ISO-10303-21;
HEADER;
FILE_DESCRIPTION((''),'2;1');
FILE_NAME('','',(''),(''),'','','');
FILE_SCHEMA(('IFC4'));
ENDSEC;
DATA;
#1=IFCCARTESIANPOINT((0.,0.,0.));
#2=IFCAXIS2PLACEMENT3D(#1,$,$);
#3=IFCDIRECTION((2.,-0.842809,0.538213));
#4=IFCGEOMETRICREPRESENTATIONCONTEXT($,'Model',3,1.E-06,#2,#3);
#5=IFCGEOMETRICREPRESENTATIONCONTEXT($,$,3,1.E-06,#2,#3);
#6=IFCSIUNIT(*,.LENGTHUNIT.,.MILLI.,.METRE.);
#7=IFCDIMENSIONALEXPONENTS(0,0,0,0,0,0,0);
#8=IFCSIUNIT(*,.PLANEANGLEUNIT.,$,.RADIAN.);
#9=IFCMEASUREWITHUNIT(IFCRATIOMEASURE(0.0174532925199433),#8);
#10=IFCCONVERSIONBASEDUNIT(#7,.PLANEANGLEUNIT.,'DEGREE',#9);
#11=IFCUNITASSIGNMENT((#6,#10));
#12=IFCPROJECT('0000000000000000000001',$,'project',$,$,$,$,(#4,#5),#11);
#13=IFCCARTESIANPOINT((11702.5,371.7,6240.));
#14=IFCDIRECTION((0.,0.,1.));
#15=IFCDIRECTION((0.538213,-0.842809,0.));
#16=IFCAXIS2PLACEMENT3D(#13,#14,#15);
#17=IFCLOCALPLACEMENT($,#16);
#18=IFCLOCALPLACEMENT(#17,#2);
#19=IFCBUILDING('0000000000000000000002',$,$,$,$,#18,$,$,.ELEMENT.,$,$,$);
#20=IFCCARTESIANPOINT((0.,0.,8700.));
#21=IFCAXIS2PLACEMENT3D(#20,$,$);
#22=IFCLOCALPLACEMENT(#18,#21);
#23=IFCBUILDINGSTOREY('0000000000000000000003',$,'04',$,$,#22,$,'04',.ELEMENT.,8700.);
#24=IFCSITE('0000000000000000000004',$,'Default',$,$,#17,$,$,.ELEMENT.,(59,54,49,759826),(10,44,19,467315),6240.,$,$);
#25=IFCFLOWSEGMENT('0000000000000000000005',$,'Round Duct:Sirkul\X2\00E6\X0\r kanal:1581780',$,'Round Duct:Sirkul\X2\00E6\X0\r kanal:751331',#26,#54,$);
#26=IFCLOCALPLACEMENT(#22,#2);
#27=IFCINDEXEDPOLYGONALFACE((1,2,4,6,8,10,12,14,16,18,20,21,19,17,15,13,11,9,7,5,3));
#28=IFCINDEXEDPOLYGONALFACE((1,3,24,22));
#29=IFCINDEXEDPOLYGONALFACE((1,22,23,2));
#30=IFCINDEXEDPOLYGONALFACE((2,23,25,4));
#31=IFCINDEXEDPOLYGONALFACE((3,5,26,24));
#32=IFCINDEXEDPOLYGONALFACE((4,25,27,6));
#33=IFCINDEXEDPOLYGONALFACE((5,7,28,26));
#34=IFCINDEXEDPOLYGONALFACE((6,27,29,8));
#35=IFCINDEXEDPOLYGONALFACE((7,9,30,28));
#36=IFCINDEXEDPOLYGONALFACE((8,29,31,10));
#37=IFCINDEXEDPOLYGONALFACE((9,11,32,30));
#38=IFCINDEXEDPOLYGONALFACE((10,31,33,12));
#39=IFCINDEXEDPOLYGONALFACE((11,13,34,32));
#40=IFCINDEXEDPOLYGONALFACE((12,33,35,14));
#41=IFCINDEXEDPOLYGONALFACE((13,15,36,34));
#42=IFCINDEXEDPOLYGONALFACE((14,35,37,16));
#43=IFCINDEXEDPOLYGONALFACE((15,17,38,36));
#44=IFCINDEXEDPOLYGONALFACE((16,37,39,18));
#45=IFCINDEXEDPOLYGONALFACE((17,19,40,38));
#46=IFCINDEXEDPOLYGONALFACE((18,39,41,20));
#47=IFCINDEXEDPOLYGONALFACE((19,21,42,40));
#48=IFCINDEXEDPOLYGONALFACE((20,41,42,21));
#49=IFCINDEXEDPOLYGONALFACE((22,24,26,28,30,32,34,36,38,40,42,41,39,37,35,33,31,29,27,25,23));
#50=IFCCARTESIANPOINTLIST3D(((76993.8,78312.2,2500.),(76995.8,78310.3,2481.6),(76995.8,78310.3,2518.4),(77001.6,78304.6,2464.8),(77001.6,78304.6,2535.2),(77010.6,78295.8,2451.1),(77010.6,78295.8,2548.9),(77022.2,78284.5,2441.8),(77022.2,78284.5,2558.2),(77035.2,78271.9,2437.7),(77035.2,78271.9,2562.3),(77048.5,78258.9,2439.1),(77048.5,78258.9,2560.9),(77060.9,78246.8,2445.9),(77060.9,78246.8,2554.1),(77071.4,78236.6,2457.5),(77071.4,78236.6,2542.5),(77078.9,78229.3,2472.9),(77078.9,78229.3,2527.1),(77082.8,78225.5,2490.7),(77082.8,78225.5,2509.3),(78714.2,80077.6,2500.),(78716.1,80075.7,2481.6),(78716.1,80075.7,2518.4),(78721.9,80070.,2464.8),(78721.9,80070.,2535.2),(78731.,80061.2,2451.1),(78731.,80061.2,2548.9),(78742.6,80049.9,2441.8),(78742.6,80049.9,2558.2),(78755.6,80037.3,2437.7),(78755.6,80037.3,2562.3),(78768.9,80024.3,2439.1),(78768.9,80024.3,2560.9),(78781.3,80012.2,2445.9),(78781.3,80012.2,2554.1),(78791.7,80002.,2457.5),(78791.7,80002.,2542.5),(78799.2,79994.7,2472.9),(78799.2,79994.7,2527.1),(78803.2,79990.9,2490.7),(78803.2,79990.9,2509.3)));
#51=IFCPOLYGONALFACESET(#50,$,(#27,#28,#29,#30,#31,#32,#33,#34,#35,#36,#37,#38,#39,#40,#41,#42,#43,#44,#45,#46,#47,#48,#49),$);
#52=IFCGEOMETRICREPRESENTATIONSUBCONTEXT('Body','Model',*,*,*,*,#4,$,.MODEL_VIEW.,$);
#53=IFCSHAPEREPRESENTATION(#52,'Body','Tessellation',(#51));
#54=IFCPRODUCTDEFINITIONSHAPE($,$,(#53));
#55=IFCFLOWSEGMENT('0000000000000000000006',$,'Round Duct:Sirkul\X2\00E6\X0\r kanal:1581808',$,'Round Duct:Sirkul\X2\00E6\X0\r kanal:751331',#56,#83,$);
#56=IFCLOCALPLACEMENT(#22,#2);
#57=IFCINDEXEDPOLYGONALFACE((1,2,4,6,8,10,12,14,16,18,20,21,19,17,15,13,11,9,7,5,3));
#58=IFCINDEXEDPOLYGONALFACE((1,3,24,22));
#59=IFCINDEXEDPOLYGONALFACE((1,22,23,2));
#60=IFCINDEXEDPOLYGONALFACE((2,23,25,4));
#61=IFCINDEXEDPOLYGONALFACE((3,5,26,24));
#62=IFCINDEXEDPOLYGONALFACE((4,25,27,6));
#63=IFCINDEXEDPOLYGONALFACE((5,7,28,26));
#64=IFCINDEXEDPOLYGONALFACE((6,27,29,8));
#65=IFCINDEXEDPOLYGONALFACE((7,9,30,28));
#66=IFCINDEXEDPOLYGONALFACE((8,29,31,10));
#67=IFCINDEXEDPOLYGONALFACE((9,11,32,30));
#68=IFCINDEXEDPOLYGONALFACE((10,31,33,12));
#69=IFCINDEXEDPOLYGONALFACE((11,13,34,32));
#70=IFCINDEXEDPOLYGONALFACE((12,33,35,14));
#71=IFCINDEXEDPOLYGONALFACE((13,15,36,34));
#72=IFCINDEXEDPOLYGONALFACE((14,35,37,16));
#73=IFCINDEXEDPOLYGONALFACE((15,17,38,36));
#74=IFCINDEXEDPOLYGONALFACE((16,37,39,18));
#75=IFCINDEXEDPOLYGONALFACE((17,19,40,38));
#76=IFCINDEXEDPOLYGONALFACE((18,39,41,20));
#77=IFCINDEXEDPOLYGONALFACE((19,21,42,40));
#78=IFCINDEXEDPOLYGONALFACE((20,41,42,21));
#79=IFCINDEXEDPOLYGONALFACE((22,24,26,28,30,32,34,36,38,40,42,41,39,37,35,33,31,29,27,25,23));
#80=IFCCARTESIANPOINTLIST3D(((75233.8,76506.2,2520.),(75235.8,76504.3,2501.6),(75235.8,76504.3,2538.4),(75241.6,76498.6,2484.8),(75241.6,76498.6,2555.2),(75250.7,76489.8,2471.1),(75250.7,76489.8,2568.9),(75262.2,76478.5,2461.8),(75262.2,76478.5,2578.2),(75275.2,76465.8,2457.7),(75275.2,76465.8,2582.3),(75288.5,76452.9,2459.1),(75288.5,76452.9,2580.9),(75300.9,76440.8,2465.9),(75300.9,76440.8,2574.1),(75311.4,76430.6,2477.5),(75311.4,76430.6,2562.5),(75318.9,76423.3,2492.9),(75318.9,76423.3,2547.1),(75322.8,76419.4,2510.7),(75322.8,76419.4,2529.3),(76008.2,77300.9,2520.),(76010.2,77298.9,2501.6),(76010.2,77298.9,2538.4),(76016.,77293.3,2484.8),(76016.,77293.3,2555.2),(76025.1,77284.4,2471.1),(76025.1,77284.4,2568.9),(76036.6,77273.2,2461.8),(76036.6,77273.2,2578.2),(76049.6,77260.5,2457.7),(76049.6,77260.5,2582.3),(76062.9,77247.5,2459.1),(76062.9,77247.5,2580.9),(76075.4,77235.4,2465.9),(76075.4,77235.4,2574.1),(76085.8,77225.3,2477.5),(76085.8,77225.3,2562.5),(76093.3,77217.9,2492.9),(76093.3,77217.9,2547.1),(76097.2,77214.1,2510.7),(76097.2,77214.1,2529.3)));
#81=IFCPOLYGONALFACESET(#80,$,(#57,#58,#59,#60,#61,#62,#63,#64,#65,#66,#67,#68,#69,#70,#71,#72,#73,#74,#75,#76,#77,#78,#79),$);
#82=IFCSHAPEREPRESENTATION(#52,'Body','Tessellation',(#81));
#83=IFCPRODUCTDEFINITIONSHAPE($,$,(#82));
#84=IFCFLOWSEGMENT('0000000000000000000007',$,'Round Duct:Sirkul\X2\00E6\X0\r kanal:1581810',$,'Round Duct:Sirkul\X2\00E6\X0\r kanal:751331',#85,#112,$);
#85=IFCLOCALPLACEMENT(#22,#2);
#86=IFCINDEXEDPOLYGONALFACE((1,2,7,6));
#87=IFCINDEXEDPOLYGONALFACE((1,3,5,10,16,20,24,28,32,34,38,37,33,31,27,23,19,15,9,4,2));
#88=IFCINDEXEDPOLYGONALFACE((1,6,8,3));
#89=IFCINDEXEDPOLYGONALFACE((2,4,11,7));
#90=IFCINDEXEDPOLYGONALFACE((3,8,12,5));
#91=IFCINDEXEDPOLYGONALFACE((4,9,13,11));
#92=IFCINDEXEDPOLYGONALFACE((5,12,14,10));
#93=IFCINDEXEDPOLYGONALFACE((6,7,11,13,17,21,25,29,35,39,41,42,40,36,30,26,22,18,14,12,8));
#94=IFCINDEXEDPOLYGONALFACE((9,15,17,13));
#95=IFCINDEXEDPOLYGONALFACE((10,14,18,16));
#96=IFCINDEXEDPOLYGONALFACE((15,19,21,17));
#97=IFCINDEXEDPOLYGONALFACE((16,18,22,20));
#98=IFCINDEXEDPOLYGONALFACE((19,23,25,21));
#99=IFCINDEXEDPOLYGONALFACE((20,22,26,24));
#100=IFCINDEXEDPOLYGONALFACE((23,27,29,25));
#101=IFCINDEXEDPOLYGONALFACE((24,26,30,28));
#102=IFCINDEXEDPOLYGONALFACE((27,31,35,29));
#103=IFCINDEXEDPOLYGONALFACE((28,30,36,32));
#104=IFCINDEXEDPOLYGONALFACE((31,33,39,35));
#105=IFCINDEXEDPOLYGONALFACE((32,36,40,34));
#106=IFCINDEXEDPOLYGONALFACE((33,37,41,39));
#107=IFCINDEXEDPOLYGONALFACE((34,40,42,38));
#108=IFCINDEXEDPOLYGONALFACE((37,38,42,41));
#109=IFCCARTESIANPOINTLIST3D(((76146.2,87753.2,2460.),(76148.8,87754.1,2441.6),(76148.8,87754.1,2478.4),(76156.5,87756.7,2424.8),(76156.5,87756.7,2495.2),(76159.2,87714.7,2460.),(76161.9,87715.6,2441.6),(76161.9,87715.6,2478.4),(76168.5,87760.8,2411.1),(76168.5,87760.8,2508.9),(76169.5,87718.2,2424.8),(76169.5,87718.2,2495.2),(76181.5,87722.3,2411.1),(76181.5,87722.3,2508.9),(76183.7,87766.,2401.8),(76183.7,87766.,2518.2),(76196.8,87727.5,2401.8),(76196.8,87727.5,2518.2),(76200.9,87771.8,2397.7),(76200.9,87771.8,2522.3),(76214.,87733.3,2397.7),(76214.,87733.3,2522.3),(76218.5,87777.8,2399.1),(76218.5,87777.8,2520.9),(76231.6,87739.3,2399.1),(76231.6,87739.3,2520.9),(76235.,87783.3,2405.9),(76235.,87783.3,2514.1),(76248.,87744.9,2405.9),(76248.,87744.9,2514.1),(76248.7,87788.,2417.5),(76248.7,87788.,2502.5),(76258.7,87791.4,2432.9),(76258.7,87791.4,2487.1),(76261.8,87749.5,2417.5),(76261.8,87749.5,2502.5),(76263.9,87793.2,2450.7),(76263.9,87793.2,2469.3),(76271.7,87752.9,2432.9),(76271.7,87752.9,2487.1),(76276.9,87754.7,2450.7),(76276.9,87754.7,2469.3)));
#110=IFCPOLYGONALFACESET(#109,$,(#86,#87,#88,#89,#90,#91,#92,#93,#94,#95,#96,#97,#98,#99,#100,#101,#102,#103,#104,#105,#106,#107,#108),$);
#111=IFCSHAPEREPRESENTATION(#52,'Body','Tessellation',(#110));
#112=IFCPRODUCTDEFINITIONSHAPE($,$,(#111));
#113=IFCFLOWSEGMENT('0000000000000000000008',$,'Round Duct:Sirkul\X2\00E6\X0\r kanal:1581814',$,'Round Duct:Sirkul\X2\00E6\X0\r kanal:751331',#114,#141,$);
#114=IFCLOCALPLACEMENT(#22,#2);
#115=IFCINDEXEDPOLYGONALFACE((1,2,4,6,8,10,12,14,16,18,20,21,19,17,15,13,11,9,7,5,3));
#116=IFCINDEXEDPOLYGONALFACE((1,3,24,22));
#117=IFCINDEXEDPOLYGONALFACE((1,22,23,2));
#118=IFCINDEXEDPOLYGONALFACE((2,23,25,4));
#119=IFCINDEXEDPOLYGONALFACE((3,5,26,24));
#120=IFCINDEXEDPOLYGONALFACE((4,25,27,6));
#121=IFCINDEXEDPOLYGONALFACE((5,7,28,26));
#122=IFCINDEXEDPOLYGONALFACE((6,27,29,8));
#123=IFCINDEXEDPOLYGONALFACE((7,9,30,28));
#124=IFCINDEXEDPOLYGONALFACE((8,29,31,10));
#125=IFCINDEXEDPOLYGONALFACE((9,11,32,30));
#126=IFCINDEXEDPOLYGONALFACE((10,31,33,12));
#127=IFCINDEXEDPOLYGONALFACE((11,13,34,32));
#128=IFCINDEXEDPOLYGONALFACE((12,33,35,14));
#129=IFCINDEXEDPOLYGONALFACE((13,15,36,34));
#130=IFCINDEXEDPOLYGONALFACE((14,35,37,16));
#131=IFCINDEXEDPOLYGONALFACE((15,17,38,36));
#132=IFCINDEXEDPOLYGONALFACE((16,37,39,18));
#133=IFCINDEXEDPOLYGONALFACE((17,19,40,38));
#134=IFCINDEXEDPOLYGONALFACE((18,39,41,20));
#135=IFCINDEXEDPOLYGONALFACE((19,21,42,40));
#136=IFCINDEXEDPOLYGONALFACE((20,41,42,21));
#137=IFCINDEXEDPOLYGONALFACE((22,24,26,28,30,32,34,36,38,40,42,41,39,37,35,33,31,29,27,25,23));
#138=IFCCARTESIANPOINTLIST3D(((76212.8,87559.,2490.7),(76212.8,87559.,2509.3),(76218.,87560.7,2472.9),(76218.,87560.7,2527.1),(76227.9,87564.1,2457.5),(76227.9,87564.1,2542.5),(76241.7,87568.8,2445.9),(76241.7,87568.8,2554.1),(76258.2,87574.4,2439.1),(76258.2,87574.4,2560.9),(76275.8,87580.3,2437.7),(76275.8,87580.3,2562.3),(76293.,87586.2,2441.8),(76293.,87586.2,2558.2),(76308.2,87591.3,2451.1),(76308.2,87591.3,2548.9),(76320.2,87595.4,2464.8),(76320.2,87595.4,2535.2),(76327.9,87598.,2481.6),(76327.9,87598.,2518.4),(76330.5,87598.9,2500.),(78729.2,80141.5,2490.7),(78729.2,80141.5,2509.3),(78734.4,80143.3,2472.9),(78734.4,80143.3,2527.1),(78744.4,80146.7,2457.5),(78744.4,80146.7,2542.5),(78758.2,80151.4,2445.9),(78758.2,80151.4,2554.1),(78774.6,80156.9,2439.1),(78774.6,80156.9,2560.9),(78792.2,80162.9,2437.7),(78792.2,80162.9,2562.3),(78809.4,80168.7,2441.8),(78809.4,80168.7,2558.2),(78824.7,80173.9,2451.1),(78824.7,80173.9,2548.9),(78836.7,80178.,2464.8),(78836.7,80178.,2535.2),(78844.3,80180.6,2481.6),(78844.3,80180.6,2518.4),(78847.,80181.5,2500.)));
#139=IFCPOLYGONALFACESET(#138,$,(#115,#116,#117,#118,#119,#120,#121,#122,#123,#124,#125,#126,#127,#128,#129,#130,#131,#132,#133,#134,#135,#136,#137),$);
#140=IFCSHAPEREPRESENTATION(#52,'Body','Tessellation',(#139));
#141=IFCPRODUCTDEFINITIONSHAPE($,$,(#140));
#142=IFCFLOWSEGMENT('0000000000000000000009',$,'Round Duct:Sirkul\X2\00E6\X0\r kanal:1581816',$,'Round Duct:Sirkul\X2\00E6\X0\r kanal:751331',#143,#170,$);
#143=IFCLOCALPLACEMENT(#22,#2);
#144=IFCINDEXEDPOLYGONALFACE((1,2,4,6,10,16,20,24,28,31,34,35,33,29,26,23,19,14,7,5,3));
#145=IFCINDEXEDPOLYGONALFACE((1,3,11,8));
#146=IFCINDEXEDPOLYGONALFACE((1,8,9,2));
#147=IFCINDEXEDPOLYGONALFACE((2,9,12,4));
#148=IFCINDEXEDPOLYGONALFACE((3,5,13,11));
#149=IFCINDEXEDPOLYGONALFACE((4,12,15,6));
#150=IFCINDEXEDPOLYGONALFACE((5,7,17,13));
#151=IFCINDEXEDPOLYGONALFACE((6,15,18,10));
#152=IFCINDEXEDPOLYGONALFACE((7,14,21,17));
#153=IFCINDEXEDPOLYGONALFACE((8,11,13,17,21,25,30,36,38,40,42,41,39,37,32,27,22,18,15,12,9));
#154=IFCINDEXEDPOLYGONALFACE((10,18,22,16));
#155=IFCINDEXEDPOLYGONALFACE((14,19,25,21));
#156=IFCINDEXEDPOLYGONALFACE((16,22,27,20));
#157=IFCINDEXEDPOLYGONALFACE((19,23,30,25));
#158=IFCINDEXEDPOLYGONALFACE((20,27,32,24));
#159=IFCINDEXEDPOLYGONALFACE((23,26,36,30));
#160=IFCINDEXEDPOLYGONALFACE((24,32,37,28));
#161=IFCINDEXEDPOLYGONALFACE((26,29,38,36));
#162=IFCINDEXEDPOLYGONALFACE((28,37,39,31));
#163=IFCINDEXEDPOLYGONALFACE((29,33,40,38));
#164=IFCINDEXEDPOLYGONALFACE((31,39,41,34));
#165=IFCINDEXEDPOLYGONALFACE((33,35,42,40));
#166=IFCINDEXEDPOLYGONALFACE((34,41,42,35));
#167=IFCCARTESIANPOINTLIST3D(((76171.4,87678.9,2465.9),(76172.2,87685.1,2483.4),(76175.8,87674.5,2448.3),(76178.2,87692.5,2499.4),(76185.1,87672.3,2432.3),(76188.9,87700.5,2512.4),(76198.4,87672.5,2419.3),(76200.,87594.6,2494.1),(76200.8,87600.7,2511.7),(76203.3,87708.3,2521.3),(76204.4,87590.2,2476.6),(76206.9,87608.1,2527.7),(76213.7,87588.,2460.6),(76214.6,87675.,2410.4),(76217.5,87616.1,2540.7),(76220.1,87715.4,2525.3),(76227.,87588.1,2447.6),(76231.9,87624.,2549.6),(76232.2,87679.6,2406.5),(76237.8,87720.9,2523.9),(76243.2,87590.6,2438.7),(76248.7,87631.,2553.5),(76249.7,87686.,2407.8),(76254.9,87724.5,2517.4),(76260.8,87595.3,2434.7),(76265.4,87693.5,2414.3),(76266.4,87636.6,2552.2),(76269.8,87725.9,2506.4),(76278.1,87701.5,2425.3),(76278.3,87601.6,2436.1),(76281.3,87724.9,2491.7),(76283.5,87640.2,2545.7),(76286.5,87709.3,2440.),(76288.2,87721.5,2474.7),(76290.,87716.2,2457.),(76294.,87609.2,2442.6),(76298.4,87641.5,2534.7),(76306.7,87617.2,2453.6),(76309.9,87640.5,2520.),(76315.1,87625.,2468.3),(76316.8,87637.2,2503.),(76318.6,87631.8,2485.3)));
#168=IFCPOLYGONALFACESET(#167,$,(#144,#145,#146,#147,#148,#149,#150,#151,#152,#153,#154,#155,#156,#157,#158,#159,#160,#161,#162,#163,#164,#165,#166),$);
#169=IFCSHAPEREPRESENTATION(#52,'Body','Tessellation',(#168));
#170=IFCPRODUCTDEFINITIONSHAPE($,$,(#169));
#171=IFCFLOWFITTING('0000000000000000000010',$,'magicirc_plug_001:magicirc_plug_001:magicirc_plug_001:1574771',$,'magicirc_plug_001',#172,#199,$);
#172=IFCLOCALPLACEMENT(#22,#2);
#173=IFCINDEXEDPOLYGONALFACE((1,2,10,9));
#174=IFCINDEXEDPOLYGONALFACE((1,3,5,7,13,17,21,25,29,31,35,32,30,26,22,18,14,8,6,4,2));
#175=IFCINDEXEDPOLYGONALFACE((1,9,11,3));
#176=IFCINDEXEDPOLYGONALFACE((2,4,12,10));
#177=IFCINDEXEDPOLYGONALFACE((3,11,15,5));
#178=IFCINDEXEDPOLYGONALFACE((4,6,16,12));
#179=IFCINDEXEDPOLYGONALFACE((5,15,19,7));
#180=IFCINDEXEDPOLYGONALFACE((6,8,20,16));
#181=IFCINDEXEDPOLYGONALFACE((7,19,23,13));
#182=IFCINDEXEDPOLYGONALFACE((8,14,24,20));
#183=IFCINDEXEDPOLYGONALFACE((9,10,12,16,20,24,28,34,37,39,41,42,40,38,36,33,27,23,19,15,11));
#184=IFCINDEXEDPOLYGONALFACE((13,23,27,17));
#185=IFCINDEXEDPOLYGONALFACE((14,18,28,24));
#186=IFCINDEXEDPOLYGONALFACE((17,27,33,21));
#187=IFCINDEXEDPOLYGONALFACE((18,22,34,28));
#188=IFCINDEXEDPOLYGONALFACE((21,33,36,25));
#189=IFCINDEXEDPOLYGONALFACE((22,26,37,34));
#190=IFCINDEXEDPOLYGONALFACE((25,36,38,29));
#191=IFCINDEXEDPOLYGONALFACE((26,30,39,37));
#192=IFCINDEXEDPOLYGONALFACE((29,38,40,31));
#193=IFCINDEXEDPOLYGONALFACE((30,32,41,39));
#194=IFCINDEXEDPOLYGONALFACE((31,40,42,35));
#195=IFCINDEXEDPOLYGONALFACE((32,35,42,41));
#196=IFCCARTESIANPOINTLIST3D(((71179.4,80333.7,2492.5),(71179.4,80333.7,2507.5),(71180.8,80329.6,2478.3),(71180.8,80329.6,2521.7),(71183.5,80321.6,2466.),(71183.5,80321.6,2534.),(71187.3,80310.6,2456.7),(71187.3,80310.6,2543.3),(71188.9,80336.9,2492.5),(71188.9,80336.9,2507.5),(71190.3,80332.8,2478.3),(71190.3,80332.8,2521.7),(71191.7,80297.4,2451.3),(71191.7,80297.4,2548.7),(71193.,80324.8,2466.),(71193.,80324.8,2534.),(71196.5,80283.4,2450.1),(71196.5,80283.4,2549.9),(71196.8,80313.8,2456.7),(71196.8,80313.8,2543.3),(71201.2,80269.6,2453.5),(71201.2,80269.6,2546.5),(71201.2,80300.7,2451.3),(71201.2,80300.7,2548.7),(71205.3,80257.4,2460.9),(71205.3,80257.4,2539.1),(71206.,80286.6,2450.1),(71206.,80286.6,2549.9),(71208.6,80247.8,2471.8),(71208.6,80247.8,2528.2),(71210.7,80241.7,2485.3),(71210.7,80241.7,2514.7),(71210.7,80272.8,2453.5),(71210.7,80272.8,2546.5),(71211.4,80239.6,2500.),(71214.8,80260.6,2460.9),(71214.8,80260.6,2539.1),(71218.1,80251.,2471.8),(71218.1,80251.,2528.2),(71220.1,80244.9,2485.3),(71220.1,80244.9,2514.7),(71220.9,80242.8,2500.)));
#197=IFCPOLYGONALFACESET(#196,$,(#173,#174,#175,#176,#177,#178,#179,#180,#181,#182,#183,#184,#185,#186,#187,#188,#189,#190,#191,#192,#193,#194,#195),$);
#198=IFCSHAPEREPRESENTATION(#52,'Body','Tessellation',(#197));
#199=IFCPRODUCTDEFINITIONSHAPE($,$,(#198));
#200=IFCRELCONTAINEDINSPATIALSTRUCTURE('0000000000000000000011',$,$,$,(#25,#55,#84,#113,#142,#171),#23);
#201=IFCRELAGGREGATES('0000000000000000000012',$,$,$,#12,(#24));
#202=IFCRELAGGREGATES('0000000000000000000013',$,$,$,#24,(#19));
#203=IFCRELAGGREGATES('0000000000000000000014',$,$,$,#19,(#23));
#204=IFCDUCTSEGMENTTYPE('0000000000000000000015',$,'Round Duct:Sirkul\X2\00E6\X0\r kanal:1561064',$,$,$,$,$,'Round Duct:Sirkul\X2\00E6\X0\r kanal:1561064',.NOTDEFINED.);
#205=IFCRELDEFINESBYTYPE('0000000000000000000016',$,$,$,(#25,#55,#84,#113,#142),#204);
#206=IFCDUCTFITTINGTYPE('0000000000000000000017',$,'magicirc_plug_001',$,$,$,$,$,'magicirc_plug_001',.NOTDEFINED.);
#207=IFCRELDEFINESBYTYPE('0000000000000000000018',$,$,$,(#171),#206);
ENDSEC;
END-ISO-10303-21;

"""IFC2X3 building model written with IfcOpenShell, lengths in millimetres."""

from ifc_helpers import new_model, entity, si_unit, converted_unit, direction, frame, frame_2d, origin, origin_2d_with_axis, place, context, subcontext, project, spatial, circle, extrude, source, transform, mapped, type_object, type_shapes, element, save


model = new_model("IFC2X3")

# Units and contexts
model_context = context("Model", 3, precision=1e-06, world=origin(), true_north=direction((2.0, -0.842809, 0.538213)))
context_of_model = context(None, 3, precision=1e-06, world=origin(), true_north=direction((2.0, -0.842809, 0.538213)))
body_context = subcontext(model_context, "Body", "Model", "MODEL_VIEW")
ifc_project = project(units=[si_unit("LENGTHUNIT", "METRE", prefix="MILLI"), converted_unit("PLANEANGLEUNIT", "DEGREE", entity("IfcRatioMeasure", 0.0174532925199433), si_unit("PLANEANGLEUNIT", "RADIAN"), dimensions=[0, 0, 0, 0, 0, 0, 0])], contexts=[model_context, context_of_model])

# Site, building, storey
site_placement = place(None, frame((11702.5, 371.7, 6240.0), z_axis=(0.0, 0.0, 1.0), x_axis=(0.538213, -0.842809, 0.0)))
site = spatial("IfcSite", under=ifc_project, at=site_placement, Name="Default", CompositionType="ELEMENT", RefLatitude=(59, 54, 49, 759826), RefLongitude=(10, 44, 19, 467315), RefElevation=6240.0)
building_placement = place(site_placement, origin())
building = spatial("IfcBuilding", under=site, at=building_placement, CompositionType="ELEMENT")
storey_placement = place(building_placement, frame((0.0, 0.0, 8700.0)))
storey = spatial("IfcBuildingStorey", under=building, at=storey_placement, Name="04", LongName="04", CompositionType="ELEMENT", Elevation=8700.0)

# Flow segments
duct_segment_type = type_object("IfcDuctSegmentType", Name="Round Duct:Sirkulær kanal:1561064", ElementType="Round Duct:Sirkulær kanal:1561064", PredefinedType="NOTDEFINED")
flow_segment_1_placement = place(storey_placement, origin())
element("IfcFlowSegment", 1, at=flow_segment_1_placement, inside=storey, type_object=duct_segment_type, Name="Round Duct:Sirkulær kanal:1581780", ObjectType="Round Duct:Sirkulær kanal:751331", context=body_context, shape_type="SweptSolid", body=[
    extrude(circle(Radius=62.5, at=frame_2d((0.0, 0.0), x_axis=(1.0, 0.0))), frame((77038.5, 78268.6, 2500.0), z_axis=(0.697915, 0.71618, 0.0), x_axis=(-0.71618, 0.697915, 0.0)), (0.0, 0.0, 1.0), 2465.0),
])
flow_segment_2_placement = place(storey_placement, origin())
element("IfcFlowSegment", 2, at=flow_segment_2_placement, inside=storey, type_object=duct_segment_type, Name="Round Duct:Sirkulær kanal:1581808", ObjectType="Round Duct:Sirkulær kanal:751331", context=body_context, shape_type="SweptSolid", body=[
    extrude(circle(Radius=62.5, at=origin_2d_with_axis()), frame((75278.6, 76462.6, 2520.0), z_axis=(0.697915, 0.71618, 0.0), x_axis=(-0.71618, 0.697915, 0.0)), (0.0, 0.0, 1.0), 1109.6),
])
flow_segment_3_placement = place(storey_placement, origin())
element("IfcFlowSegment", 3, at=flow_segment_3_placement, inside=storey, type_object=duct_segment_type, Name="Round Duct:Sirkulær kanal:1581810", ObjectType="Round Duct:Sirkulær kanal:751331", context=body_context, shape_type="SweptSolid", body=[
    extrude(circle(Radius=62.5, at=origin_2d_with_axis()), frame((76218.4, 87734.8, 2460.0), z_axis=(-0.321245, 0.946996, 0.0), x_axis=(-0.946996, -0.321245, 0.0)), (0.0, 0.0, 1.0), 40.6),
])
flow_segment_4_placement = place(storey_placement, origin())
element("IfcFlowSegment", 4, at=flow_segment_4_placement, inside=storey, type_object=duct_segment_type, Name="Round Duct:Sirkulær kanal:1581814", ObjectType="Round Duct:Sirkulær kanal:751331", context=body_context, shape_type="SweptSolid", body=[
    extrude(circle(Radius=62.5, at=origin_2d_with_axis()), frame((76271.3, 87578.8, 2500.0), z_axis=(0.321274, -0.946986, 0.0), x_axis=(0.946986, 0.321274, 0.0)), (0.0, 0.0, 1.0), 7832.7),
])
flow_segment_5_placement = place(storey_placement, origin())
element("IfcFlowSegment", 5, at=flow_segment_5_placement, inside=storey, type_object=duct_segment_type, Name="Round Duct:Sirkulær kanal:1581816", ObjectType="Round Duct:Sirkulær kanal:751331", context=body_context, shape_type="SweptSolid", body=[
    extrude(circle(Radius=62.5, at=frame_2d((0.0, 0.0), x_axis=(1.0, 0.0))), frame((76230.6, 87699.0, 2465.9), z_axis=(0.306214, -0.902596, 0.302579), x_axis=(-0.946986, -0.321274, 0.0)), (0.0, 0.0, 1.0), 93.5),
])

# Flow fitting
duct_fitting_type_1 = type_object("IfcDuctFittingType", Name="magicirc_plug_001", ElementType="magicirc_plug_001", PredefinedType="NOTDEFINED")
shared_shape_1 = source(origin(), body_context, "Body", "SweptSolid", [
    extrude(circle(Radius=50.0, at=frame_2d((0.0, 0.0), x_axis=(1.0, 0.0))), frame((0.0, 0.0, 0.0), z_axis=(1.0, 0.0, 0.0), x_axis=(0.0, 1.0, 0.0)), (0.0, 0.0, 1.0), 10.0),
])
type_shapes(duct_fitting_type_1, [shared_shape_1])
flow_fitting_placement = place(storey_placement, frame((71204.8, 80290.1, 2500.0), z_axis=(0.0, 0.0, 1.0), x_axis=(-0.946986, -0.321274, 0.0)))
element("IfcFlowFitting", 6, at=flow_fitting_placement, inside=storey, type_object=duct_fitting_type_1, Name="magicirc_plug_001:magicirc_plug_001:magicirc_plug_001:1574771", ObjectType="magicirc_plug_001", context=body_context, shape_type="MappedRepresentation", body=[
    mapped(shared_shape_1, transform((0.0, 0.0, 0.0), scale=1.0)),
])

save(model, "model.ifc")
